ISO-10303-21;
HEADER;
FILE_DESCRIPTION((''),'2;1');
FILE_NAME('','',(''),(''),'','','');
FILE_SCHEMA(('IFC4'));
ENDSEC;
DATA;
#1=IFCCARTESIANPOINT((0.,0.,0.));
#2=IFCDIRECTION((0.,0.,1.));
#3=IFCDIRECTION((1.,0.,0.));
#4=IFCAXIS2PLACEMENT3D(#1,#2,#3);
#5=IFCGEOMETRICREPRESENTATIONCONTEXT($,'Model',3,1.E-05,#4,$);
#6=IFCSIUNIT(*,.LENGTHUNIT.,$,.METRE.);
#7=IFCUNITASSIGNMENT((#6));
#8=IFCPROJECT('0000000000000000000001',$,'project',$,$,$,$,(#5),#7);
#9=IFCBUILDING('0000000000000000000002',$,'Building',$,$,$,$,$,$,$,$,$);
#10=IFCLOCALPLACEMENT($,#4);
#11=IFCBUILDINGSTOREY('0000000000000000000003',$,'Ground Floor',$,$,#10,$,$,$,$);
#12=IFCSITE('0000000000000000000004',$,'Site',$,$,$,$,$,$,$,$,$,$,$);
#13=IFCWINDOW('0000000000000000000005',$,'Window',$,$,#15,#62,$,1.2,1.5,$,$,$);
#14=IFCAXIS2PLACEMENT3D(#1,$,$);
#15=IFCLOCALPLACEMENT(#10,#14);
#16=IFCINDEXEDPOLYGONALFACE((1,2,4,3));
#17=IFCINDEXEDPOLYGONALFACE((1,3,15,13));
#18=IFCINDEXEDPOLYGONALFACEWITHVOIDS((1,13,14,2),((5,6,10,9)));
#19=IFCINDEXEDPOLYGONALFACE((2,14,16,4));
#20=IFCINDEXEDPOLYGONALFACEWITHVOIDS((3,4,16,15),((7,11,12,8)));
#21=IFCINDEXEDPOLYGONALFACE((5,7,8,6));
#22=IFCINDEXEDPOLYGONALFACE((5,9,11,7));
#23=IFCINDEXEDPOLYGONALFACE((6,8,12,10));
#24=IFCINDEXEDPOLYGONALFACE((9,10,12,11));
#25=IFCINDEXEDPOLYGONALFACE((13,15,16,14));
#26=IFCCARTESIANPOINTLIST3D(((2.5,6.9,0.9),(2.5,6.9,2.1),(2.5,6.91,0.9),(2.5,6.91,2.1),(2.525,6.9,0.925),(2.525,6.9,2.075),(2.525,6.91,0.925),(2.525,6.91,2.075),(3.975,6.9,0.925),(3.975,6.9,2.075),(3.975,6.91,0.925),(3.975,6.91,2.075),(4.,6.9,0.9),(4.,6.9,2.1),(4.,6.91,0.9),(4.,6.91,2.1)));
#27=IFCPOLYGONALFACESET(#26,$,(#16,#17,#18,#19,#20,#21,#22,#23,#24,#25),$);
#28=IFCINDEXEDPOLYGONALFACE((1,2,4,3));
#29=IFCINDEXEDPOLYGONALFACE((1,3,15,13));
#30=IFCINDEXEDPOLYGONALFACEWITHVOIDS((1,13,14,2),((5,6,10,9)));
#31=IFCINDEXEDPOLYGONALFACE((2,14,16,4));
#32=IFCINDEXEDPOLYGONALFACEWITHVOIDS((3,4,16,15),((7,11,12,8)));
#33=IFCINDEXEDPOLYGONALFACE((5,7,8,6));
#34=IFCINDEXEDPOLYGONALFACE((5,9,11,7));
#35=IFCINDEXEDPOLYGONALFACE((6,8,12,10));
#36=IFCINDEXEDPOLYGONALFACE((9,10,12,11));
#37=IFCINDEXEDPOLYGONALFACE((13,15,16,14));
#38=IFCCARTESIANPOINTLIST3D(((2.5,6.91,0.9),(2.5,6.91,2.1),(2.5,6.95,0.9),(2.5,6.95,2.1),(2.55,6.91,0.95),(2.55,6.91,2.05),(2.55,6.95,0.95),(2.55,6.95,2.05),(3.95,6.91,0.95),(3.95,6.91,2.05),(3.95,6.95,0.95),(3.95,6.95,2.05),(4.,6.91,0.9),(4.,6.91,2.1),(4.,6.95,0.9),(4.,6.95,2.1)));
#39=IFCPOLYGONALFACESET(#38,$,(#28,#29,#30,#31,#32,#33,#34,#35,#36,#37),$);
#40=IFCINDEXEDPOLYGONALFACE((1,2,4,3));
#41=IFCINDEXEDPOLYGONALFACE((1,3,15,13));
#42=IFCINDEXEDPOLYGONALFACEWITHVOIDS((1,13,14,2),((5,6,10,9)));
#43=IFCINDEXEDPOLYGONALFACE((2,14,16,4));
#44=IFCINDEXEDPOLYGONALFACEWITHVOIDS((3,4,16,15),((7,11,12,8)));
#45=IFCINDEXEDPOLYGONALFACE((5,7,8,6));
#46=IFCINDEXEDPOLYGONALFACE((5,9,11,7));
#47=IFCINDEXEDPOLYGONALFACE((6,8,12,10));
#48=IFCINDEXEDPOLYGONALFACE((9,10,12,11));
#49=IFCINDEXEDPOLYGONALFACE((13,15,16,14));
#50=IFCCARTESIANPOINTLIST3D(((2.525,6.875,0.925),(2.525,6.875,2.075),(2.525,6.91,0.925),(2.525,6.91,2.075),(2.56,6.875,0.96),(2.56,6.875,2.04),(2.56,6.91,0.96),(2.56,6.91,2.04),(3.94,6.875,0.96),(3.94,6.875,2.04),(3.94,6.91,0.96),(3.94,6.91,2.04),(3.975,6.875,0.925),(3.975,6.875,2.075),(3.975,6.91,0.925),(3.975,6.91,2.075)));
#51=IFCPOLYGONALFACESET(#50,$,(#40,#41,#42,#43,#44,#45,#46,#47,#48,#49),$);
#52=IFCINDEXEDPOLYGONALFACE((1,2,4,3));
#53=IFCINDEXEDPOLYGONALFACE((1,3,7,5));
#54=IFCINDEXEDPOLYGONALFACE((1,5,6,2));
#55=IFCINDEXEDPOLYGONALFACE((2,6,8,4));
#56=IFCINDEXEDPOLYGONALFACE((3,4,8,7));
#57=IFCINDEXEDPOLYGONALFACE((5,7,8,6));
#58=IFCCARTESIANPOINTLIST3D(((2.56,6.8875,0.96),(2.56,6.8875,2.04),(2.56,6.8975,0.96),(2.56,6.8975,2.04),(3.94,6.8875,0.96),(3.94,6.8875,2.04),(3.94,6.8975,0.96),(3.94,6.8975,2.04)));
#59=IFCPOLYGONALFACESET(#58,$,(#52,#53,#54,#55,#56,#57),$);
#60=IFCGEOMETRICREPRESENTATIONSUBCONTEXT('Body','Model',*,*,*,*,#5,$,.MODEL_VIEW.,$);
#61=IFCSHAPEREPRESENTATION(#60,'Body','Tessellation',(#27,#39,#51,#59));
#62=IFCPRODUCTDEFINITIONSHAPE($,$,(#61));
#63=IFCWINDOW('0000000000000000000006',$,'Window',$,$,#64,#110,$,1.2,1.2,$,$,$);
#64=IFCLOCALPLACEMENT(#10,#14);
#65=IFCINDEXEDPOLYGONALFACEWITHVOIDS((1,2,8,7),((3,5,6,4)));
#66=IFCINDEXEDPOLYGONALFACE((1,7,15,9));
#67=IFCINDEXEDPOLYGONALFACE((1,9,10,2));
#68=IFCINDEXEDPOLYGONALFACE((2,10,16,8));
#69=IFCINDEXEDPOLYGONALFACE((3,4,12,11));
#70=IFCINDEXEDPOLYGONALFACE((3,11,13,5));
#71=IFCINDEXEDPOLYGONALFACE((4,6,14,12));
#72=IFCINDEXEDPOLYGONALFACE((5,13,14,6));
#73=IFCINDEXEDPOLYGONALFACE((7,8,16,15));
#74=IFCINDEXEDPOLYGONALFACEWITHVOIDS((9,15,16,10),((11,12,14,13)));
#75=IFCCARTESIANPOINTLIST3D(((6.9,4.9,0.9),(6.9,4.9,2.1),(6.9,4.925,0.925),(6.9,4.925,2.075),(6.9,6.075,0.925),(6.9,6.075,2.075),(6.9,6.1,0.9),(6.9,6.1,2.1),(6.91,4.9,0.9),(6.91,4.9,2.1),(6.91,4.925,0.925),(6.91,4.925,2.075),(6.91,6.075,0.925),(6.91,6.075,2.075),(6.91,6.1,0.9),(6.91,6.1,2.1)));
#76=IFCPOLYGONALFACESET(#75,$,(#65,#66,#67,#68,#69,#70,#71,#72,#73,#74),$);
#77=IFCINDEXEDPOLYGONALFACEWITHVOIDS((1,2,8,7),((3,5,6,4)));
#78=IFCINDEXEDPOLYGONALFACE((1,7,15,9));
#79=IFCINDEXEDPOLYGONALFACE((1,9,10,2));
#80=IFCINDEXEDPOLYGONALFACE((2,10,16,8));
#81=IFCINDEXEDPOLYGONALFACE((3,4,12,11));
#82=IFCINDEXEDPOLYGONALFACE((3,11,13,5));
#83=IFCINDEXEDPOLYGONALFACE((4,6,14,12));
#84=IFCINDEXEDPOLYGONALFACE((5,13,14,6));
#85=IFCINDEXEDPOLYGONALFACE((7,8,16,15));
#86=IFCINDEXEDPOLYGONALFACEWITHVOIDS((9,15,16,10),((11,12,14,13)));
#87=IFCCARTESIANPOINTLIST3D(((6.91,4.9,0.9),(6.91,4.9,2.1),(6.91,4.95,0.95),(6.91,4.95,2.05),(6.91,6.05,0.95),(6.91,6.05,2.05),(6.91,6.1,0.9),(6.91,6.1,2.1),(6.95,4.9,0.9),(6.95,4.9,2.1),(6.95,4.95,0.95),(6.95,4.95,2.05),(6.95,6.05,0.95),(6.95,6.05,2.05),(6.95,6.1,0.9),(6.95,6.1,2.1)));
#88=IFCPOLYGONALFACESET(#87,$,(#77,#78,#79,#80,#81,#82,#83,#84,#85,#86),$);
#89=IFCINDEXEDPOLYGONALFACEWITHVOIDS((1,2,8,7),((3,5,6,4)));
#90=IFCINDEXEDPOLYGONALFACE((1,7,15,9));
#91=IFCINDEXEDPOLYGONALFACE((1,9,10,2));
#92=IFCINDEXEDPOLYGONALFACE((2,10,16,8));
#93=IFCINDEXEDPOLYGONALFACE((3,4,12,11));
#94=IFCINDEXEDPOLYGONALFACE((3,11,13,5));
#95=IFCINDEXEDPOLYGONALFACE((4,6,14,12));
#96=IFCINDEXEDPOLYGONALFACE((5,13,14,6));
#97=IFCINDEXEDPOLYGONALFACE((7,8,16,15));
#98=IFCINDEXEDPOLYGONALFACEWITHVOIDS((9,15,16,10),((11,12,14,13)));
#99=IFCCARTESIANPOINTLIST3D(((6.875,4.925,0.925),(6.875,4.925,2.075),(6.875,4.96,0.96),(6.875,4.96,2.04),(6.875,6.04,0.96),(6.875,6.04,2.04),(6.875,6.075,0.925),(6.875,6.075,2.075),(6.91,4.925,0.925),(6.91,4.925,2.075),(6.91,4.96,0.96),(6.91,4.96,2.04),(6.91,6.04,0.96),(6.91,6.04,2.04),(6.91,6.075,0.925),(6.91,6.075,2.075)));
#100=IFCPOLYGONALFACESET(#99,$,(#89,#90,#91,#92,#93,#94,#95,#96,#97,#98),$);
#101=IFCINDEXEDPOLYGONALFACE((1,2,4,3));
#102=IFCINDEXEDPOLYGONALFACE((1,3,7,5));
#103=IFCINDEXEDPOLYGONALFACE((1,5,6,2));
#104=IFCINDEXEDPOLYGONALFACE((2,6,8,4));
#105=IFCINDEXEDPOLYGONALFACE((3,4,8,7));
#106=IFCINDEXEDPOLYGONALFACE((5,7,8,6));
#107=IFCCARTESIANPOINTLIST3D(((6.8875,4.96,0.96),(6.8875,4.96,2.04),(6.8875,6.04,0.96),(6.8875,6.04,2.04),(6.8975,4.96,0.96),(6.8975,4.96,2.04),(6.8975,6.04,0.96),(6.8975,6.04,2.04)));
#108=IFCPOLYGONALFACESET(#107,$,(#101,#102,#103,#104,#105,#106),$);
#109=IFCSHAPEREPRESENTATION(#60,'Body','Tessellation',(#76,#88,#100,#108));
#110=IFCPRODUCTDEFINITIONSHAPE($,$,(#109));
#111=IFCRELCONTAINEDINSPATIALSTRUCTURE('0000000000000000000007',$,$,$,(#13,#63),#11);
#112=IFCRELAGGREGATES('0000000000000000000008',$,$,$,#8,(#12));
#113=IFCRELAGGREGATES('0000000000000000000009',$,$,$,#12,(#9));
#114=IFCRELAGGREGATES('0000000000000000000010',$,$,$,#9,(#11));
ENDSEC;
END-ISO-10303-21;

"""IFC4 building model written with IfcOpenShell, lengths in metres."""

from ifc_helpers import new_model, si_unit, frame, origin_with_axes, place, context, subcontext, project, spatial, line, indexed_curve, outline, extrude, element, save


model = new_model("IFC4")

# Units and contexts
model_context = context("Model", 3, precision=1e-05, world=origin_with_axes())
body_context = subcontext(model_context, "Body", "Model", "MODEL_VIEW")
ifc_project = project(units=[si_unit("LENGTHUNIT", "METRE")], contexts=[model_context])

# Site, building, storey
site = spatial("IfcSite", under=ifc_project, Name="Site")
building = spatial("IfcBuilding", under=site, Name="Building")
storey_placement = place(None, origin_with_axes())
storey = spatial("IfcBuildingStorey", under=building, at=storey_placement, Name="Ground Floor")

# Windows
window_1_placement = place(storey_placement, frame((4.0, 7.0, 0.9), z_axis=(0.0, 0.0, 1.0), x_axis=(-1.0, 0.0, 0.0)))
element("IfcWindow", 1, at=window_1_placement, inside=storey, Name="Window", OverallHeight=1.2, OverallWidth=1.5, context=body_context, shape_type="SweptSolid", body=[
    extrude(outline(indexed_curve([(0.0, 0.0), (1.5, 0.0), (1.5, 1.2), (0.0, 1.2)], segments=[line(1, 2, 3, 4, 1)]), holes=[indexed_curve([(0.025, 0.025), (1.475, 0.025), (1.475, 1.175), (0.025, 1.175)], segments=[line(1, 2, 3, 4, 1)])]), frame((0.0, 0.09, 0.0), z_axis=(0.0, -1.0, 0.0), x_axis=(1.0, 0.0, 0.0)), (0.0, 0.0, -1.0), 0.01),
    extrude(outline(indexed_curve([(0.0, 0.0), (1.5, 0.0), (1.5, 1.2), (0.0, 1.2)], segments=[line(1, 2, 3, 4, 1)]), holes=[indexed_curve([(0.05, 0.05), (1.45, 0.05), (1.45, 1.15), (0.05, 1.15)], segments=[line(1, 2, 3, 4, 1)])]), frame((0.0, 0.05, 0.0), z_axis=(0.0, -1.0, 0.0), x_axis=(1.0, 0.0, 0.0)), (0.0, 0.0, -1.0), 0.04),
    extrude(outline(indexed_curve([(0.0, 0.0), (1.45, 0.0), (1.45, 1.15), (0.0, 1.15)], segments=[line(1, 2, 3, 4, 1)]), holes=[indexed_curve([(0.035, 0.035), (1.415, 0.035), (1.415, 1.115), (0.035, 1.115)], segments=[line(1, 2, 3, 4, 1)])]), frame((0.025, 0.09, 0.025), z_axis=(0.0, -1.0, 0.0), x_axis=(1.0, 0.0, 0.0)), (0.0, 0.0, -1.0), 0.035),
    extrude(outline(indexed_curve([(0.035, 0.035), (1.415, 0.035), (1.415, 1.115), (0.035, 1.115)], segments=[line(1, 2, 3, 4, 1)])), frame((0.025, 0.1025, 0.025), z_axis=(0.0, -1.0, 0.0), x_axis=(1.0, 0.0, 0.0)), (0.0, 0.0, -1.0), 0.01),
])
window_2_placement = place(storey_placement, frame((7.0, 4.9, 0.9), z_axis=(0.0, 0.0, 1.0), x_axis=(0.0, 1.0, 0.0)))
element("IfcWindow", 2, at=window_2_placement, inside=storey, Name="Window", OverallHeight=1.2, OverallWidth=1.2, context=body_context, shape_type="SweptSolid", body=[
    extrude(outline(indexed_curve([(0.0, 0.0), (1.2, 0.0), (1.2, 1.2), (0.0, 1.2)], segments=[line(1, 2, 3, 4, 1)]), holes=[indexed_curve([(0.025, 0.025), (1.175, 0.025), (1.175, 1.175), (0.025, 1.175)], segments=[line(1, 2, 3, 4, 1)])]), frame((0.0, 0.09, 0.0), z_axis=(0.0, -1.0, 0.0), x_axis=(1.0, 0.0, 0.0)), (0.0, 0.0, -1.0), 0.01),
    extrude(outline(indexed_curve([(0.0, 0.0), (1.2, 0.0), (1.2, 1.2), (0.0, 1.2)], segments=[line(1, 2, 3, 4, 1)]), holes=[indexed_curve([(0.05, 0.05), (1.15, 0.05), (1.15, 1.15), (0.05, 1.15)], segments=[line(1, 2, 3, 4, 1)])]), frame((0.0, 0.05, 0.0), z_axis=(0.0, -1.0, 0.0), x_axis=(1.0, 0.0, 0.0)), (0.0, 0.0, -1.0), 0.04),
    extrude(outline(indexed_curve([(0.0, 0.0), (1.15, 0.0), (1.15, 1.15), (0.0, 1.15)], segments=[line(1, 2, 3, 4, 1)]), holes=[indexed_curve([(0.035, 0.035), (1.115, 0.035), (1.115, 1.115), (0.035, 1.115)], segments=[line(1, 2, 3, 4, 1)])]), frame((0.025, 0.09, 0.025), z_axis=(0.0, -1.0, 0.0), x_axis=(1.0, 0.0, 0.0)), (0.0, 0.0, -1.0), 0.035),
    extrude(outline(indexed_curve([(0.035, 0.035), (1.115, 0.035), (1.115, 1.115), (0.035, 1.115)], segments=[line(1, 2, 3, 4, 1)])), frame((0.025, 0.1025, 0.025), z_axis=(0.0, -1.0, 0.0), x_axis=(1.0, 0.0, 0.0)), (0.0, 0.0, -1.0), 0.01),
])

save(model, "model.ifc")
